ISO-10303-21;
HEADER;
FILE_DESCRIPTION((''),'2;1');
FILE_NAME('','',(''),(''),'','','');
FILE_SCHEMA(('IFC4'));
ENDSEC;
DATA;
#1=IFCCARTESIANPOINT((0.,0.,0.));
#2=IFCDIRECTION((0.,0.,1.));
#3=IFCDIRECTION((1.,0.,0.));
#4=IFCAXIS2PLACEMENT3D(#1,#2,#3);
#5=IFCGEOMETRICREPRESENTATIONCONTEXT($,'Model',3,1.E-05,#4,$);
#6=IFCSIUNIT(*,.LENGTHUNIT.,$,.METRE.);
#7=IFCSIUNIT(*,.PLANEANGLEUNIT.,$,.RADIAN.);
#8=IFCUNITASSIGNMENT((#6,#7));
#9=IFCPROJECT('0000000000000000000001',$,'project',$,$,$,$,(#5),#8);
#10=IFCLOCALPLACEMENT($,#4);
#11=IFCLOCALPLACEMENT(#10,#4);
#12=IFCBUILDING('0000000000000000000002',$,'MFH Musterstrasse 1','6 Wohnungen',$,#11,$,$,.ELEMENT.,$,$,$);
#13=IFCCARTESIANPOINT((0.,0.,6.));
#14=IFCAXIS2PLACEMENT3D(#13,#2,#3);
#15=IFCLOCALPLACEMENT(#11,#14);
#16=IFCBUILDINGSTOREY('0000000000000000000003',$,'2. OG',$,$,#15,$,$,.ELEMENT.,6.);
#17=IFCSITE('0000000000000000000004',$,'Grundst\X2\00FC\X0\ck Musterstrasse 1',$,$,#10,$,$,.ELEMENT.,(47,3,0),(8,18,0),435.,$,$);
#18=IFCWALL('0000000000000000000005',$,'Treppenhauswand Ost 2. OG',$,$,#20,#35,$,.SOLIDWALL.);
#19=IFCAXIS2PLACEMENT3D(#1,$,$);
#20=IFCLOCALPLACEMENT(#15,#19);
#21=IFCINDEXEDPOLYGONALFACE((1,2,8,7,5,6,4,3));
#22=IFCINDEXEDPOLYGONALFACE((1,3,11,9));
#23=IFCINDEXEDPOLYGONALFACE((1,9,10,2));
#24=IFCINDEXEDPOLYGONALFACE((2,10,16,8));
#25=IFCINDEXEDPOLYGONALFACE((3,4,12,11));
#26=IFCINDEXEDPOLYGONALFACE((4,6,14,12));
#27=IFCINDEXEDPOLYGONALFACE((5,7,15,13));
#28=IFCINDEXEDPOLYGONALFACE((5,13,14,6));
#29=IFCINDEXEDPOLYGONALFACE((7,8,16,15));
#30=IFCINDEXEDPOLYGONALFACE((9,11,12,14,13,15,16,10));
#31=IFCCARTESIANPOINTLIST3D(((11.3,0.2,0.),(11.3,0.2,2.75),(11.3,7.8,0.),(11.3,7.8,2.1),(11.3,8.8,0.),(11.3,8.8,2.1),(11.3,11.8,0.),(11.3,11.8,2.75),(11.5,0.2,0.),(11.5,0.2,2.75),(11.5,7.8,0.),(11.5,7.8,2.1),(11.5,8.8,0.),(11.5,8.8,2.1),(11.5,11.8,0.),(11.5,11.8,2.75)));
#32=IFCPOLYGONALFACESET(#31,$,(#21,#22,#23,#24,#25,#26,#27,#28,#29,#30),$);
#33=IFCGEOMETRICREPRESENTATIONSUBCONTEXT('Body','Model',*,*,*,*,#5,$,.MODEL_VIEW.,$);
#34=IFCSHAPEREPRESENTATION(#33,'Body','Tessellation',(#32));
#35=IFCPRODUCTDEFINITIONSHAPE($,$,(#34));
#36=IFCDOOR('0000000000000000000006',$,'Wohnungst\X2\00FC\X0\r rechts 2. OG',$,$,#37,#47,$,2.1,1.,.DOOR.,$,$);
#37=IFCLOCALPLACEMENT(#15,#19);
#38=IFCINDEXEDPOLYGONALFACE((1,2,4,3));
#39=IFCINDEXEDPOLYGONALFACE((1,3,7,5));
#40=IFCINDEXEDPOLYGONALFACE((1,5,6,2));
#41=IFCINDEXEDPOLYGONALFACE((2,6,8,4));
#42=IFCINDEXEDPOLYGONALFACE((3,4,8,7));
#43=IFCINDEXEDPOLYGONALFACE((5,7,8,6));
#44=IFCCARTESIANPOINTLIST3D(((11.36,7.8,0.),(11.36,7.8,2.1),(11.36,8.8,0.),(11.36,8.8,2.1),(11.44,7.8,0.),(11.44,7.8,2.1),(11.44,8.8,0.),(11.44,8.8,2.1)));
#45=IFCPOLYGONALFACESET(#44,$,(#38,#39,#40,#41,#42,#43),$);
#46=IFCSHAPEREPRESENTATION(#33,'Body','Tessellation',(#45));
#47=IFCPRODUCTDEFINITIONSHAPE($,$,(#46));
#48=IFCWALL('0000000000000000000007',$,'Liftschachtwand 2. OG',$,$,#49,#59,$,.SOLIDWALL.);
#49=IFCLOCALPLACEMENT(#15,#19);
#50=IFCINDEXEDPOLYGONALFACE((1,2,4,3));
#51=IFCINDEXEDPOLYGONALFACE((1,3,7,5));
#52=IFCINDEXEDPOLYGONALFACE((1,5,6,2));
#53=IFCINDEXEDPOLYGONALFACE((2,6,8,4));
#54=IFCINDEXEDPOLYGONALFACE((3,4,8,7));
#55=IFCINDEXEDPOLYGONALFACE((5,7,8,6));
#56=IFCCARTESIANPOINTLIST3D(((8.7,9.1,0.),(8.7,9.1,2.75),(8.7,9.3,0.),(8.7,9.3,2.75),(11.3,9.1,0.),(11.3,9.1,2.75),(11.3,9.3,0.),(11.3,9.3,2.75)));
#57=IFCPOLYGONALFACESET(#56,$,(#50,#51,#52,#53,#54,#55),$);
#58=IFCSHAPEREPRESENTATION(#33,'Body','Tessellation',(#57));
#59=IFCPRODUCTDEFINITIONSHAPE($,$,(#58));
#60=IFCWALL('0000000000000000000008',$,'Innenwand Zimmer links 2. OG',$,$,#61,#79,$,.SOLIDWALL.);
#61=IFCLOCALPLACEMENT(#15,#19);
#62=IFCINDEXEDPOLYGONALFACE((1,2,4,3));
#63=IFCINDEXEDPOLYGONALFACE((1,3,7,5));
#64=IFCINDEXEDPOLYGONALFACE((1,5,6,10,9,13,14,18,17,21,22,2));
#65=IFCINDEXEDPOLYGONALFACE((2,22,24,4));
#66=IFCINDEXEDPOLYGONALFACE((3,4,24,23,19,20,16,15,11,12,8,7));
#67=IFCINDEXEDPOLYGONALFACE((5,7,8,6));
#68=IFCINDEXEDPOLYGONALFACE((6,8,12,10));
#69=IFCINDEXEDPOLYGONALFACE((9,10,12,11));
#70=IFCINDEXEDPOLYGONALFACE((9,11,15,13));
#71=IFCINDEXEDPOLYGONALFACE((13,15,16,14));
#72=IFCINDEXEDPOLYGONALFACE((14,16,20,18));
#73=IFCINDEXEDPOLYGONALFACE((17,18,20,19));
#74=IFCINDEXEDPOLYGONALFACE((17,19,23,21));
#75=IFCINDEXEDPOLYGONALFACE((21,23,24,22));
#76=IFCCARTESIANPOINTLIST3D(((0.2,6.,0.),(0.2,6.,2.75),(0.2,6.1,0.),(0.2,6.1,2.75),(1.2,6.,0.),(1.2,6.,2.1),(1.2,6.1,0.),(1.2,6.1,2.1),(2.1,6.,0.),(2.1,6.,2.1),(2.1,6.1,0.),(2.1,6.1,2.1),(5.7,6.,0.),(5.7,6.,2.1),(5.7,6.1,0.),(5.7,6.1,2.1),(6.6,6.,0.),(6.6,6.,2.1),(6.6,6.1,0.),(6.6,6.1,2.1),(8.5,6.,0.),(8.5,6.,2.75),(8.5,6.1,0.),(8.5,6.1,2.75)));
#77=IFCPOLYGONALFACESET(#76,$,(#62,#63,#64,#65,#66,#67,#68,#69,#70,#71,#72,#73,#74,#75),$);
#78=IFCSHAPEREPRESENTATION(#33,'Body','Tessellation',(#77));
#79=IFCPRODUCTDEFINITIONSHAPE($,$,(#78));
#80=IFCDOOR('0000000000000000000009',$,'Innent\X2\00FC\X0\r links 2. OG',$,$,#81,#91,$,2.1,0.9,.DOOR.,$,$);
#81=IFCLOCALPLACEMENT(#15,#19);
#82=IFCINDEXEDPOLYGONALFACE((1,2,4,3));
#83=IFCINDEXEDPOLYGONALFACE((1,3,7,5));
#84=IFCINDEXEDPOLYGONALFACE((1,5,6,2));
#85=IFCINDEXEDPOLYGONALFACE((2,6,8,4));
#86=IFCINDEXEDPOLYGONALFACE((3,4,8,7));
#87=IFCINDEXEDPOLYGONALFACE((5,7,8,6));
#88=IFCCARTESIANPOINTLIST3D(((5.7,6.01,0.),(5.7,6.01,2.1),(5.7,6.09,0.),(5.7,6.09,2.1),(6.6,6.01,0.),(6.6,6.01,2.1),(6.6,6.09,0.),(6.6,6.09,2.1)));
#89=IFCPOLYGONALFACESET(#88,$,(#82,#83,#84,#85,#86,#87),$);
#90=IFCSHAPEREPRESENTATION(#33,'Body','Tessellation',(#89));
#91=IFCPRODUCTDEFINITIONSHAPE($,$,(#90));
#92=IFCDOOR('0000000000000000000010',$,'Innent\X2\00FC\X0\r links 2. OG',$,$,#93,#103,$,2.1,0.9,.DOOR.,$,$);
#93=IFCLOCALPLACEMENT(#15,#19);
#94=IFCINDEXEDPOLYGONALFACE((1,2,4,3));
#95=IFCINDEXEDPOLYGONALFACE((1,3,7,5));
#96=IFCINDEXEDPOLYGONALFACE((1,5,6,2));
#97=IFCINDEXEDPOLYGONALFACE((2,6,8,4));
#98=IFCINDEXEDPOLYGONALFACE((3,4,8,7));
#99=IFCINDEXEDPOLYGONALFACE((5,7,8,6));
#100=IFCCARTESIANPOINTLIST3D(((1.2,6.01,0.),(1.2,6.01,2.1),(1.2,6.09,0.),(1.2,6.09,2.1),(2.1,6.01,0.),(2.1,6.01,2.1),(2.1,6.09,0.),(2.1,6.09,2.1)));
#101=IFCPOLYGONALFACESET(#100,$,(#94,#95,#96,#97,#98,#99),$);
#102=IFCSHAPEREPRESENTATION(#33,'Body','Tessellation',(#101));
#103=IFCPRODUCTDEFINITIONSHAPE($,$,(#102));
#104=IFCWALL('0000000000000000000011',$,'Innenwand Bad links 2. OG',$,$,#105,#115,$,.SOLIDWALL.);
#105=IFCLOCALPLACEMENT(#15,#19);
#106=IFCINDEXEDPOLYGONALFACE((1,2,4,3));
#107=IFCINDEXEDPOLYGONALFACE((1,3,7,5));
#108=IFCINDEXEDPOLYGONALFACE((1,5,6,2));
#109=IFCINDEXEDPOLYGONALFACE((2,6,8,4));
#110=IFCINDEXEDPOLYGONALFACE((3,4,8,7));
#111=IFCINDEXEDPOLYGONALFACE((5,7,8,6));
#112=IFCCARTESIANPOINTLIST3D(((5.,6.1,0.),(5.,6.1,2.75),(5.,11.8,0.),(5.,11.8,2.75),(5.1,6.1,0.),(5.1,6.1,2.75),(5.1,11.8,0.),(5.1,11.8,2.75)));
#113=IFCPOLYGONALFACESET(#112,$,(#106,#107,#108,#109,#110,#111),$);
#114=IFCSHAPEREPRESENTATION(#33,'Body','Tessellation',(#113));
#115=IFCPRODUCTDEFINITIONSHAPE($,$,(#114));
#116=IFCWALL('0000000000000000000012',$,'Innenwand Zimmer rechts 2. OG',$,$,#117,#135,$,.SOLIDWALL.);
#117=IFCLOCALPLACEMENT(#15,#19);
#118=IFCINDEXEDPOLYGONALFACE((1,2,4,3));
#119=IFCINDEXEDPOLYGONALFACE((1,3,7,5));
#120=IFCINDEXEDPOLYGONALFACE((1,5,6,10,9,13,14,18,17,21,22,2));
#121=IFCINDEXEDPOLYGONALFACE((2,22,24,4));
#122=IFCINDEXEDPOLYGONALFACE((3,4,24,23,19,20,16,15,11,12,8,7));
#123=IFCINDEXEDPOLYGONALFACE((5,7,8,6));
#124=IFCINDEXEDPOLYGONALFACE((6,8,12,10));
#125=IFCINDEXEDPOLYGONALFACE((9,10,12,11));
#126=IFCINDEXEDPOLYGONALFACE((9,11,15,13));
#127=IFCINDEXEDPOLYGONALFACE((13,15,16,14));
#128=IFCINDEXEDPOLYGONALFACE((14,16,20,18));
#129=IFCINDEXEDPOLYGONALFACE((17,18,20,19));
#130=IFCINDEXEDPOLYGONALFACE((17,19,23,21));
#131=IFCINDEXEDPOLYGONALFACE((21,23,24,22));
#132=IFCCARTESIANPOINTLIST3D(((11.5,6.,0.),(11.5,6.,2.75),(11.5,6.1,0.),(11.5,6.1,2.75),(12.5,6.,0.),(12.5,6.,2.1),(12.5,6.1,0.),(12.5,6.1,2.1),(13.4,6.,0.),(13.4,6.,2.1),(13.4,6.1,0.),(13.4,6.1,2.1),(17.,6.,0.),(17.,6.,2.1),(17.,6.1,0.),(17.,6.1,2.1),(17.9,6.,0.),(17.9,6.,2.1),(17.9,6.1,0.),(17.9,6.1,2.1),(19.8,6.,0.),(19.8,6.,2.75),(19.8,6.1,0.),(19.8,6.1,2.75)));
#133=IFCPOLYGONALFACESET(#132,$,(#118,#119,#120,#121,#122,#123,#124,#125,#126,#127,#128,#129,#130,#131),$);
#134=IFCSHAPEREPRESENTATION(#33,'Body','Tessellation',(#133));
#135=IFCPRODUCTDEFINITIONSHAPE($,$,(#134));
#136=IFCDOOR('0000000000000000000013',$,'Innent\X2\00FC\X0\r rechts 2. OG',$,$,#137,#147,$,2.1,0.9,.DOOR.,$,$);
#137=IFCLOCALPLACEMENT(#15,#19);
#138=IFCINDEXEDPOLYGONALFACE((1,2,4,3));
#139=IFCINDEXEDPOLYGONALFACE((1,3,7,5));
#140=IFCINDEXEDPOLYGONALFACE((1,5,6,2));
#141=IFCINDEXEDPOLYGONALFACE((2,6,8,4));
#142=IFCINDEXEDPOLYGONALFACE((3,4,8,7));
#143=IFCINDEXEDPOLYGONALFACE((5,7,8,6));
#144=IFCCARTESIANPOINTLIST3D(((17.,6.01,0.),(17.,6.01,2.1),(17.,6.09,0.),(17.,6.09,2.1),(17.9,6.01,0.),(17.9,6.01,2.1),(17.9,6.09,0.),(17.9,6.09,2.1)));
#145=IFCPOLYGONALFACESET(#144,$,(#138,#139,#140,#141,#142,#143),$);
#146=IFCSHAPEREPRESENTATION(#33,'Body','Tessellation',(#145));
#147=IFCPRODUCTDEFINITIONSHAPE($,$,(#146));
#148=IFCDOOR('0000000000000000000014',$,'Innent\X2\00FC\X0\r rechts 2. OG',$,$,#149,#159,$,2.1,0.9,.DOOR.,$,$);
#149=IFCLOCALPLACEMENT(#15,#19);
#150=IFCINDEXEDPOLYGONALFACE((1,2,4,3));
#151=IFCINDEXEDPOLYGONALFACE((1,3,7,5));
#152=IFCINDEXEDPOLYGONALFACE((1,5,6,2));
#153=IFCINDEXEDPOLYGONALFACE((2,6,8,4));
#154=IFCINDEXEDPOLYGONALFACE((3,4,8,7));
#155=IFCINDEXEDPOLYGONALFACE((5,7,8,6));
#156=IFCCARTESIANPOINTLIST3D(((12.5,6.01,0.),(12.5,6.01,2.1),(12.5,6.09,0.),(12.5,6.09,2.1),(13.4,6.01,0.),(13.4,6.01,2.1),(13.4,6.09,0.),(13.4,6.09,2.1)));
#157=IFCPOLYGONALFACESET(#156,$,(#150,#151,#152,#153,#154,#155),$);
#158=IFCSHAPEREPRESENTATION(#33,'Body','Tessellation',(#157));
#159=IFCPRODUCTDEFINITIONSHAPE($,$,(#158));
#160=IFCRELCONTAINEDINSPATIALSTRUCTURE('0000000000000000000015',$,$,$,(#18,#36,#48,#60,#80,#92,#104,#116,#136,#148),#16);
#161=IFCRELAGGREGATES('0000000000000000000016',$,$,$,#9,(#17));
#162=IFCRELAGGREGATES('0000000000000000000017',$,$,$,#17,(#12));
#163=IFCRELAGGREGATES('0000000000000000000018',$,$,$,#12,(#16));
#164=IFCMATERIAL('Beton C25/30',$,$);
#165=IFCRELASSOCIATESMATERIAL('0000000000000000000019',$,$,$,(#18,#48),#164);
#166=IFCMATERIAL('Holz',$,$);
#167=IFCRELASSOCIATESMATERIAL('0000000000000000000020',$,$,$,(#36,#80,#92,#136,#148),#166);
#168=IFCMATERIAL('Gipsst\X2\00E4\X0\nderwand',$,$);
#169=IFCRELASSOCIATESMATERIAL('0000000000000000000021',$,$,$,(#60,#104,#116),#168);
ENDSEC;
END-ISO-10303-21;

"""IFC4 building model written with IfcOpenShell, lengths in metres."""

from ifc_helpers import new_model, si_unit, frame, frame_2d, origin_with_axes, place, context, subcontext, project, spatial, rectangle, extrude, material, element, fill, save


model = new_model("IFC4")

# Units and contexts
model_context = context("Model", 3, precision=1e-05, world=origin_with_axes())
body_context = subcontext(model_context, "Body", "Model", "MODEL_VIEW")
ifc_project = project(units=[si_unit("LENGTHUNIT", "METRE"), si_unit("PLANEANGLEUNIT", "RADIAN")], contexts=[model_context])

# Site, building, storey
site_placement = place(None, origin_with_axes())
site = spatial("IfcSite", under=ifc_project, at=site_placement, Name="Grundstück Musterstrasse 1", CompositionType="ELEMENT", RefLatitude=(47, 3, 0), RefLongitude=(8, 18, 0), RefElevation=435.0)
building_placement = place(site_placement, origin_with_axes())
building = spatial("IfcBuilding", under=site, at=building_placement, Name="MFH Musterstrasse 1", Description="6 Wohnungen", CompositionType="ELEMENT")
storey_placement = place(building_placement, frame((0.0, 0.0, 6.0), z_axis=(0.0, 0.0, 1.0), x_axis=(1.0, 0.0, 0.0)))
storey = spatial("IfcBuildingStorey", under=building, at=storey_placement, Name="2. OG", CompositionType="ELEMENT", Elevation=6.0)

# Wall, openings, door
ifc_material_1 = material(Name="Beton C25/30")
wall_1_placement = place(storey_placement, origin_with_axes())
wall_1 = element("IfcWall", 1, at=wall_1_placement, inside=storey, material=ifc_material_1, Name="Treppenhauswand Ost 2. OG", PredefinedType="SOLIDWALL", context=body_context, shape_type="SweptSolid", body=[
    extrude(rectangle(XDim=0.2, YDim=11.6, at=frame_2d((0.1, 5.8), x_axis=(1.0, 0.0))), frame((11.3, 0.2, 0.0), z_axis=(0.0, 0.0, 1.0), x_axis=(1.0, 0.0, 0.0)), (0.0, 0.0, 1.0), 2.75),
])
opening_1_placement = place(storey_placement, origin_with_axes())
element("IfcOpeningElement", 2, at=opening_1_placement, cuts=wall_1, PredefinedType="OPENING", context=body_context, shape_type="SweptSolid", body=[
    extrude(rectangle(XDim=0.3, YDim=1.0, at=frame_2d((0.15, 0.5), x_axis=(1.0, 0.0))), frame((11.25, 7.8, 0.0), z_axis=(0.0, 0.0, 1.0), x_axis=(1.0, 0.0, 0.0)), (0.0, 0.0, 1.0), 2.1),
])
opening_2_placement = place(storey_placement, origin_with_axes())
opening_2 = element("IfcOpeningElement", 3, at=opening_2_placement, cuts=wall_1, PredefinedType="OPENING", context=body_context, shape_type="SweptSolid", body=[
    extrude(rectangle(XDim=0.22, YDim=1.0, at=frame_2d((0.11, 0.5), x_axis=(1.0, 0.0))), frame((11.29, 7.8, 0.0), z_axis=(0.0, 0.0, 1.0), x_axis=(1.0, 0.0, 0.0)), (0.0, 0.0, 1.0), 2.1),
])
ifc_material_2 = material(Name="Holz")
door_1_placement = place(storey_placement, origin_with_axes())
door_1 = element("IfcDoor", 4, at=door_1_placement, inside=storey, material=ifc_material_2, Name="Wohnungstür rechts 2. OG", OverallHeight=2.1, OverallWidth=1.0, PredefinedType="DOOR", context=body_context, shape_type="SweptSolid", body=[
    extrude(rectangle(XDim=0.08, YDim=1.0, at=frame_2d((0.04, 0.5), x_axis=(1.0, 0.0))), frame((11.36, 7.8, 0.0), z_axis=(0.0, 0.0, 1.0), x_axis=(1.0, 0.0, 0.0)), (0.0, 0.0, 1.0), 2.1),
])
fill(opening_2, door_1)

# Wall
wall_2_placement = place(storey_placement, origin_with_axes())
element("IfcWall", 5, at=wall_2_placement, inside=storey, material=ifc_material_1, Name="Liftschachtwand 2. OG", PredefinedType="SOLIDWALL", context=body_context, shape_type="SweptSolid", body=[
    extrude(rectangle(XDim=2.6, YDim=0.2, at=frame_2d((1.3, 0.1), x_axis=(1.0, 0.0))), frame((8.7, 9.1, 0.0), z_axis=(0.0, 0.0, 1.0), x_axis=(1.0, 0.0, 0.0)), (0.0, 0.0, 1.0), 2.75),
])

# Wall, openings, doors
ifc_material_3 = material(Name="Gipsständerwand")
wall_3_placement = place(storey_placement, origin_with_axes())
wall_3 = element("IfcWall", 6, at=wall_3_placement, inside=storey, material=ifc_material_3, Name="Innenwand Zimmer links 2. OG", PredefinedType="SOLIDWALL", context=body_context, shape_type="SweptSolid", body=[
    extrude(rectangle(XDim=8.3, YDim=0.1, at=frame_2d((4.15, 0.05), x_axis=(1.0, 0.0))), frame((0.2, 6.0, 0.0), z_axis=(0.0, 0.0, 1.0), x_axis=(1.0, 0.0, 0.0)), (0.0, 0.0, 1.0), 2.75),
])
opening_3_placement = place(storey_placement, origin_with_axes())
element("IfcOpeningElement", 7, at=opening_3_placement, cuts=wall_3, PredefinedType="OPENING", context=body_context, shape_type="SweptSolid", body=[
    extrude(rectangle(XDim=0.9, YDim=0.2, at=frame_2d((0.45, 0.1), x_axis=(1.0, 0.0))), frame((5.7, 5.95, 0.0), z_axis=(0.0, 0.0, 1.0), x_axis=(1.0, 0.0, 0.0)), (0.0, 0.0, 1.0), 2.1),
])
opening_4_placement = place(storey_placement, origin_with_axes())
element("IfcOpeningElement", 8, at=opening_4_placement, cuts=wall_3, PredefinedType="OPENING", context=body_context, shape_type="SweptSolid", body=[
    extrude(rectangle(XDim=0.9, YDim=0.2, at=frame_2d((0.45, 0.1), x_axis=(1.0, 0.0))), frame((1.2, 5.95, 0.0), z_axis=(0.0, 0.0, 1.0), x_axis=(1.0, 0.0, 0.0)), (0.0, 0.0, 1.0), 2.1),
])
opening_5_placement = place(storey_placement, origin_with_axes())
opening_5 = element("IfcOpeningElement", 9, at=opening_5_placement, cuts=wall_3, PredefinedType="OPENING", context=body_context, shape_type="SweptSolid", body=[
    extrude(rectangle(XDim=0.9, YDim=0.12, at=frame_2d((0.45, 0.06), x_axis=(1.0, 0.0))), frame((5.7, 5.99, 0.0), z_axis=(0.0, 0.0, 1.0), x_axis=(1.0, 0.0, 0.0)), (0.0, 0.0, 1.0), 2.1),
])
opening_6_placement = place(storey_placement, origin_with_axes())
opening_6 = element("IfcOpeningElement", 10, at=opening_6_placement, cuts=wall_3, PredefinedType="OPENING", context=body_context, shape_type="SweptSolid", body=[
    extrude(rectangle(XDim=0.9, YDim=0.12, at=frame_2d((0.45, 0.06), x_axis=(1.0, 0.0))), frame((1.2, 5.99, 0.0), z_axis=(0.0, 0.0, 1.0), x_axis=(1.0, 0.0, 0.0)), (0.0, 0.0, 1.0), 2.1),
])
door_2_placement = place(storey_placement, origin_with_axes())
door_2 = element("IfcDoor", 11, at=door_2_placement, inside=storey, material=ifc_material_2, Name="Innentür links 2. OG", OverallHeight=2.1, OverallWidth=0.9, PredefinedType="DOOR", context=body_context, shape_type="SweptSolid", body=[
    extrude(rectangle(XDim=0.9, YDim=0.08, at=frame_2d((0.45, 0.04), x_axis=(1.0, 0.0))), frame((5.7, 6.01, 0.0), z_axis=(0.0, 0.0, 1.0), x_axis=(1.0, 0.0, 0.0)), (0.0, 0.0, 1.0), 2.1),
])
fill(opening_5, door_2)
door_3_placement = place(storey_placement, origin_with_axes())
door_3 = element("IfcDoor", 12, at=door_3_placement, inside=storey, material=ifc_material_2, Name="Innentür links 2. OG", OverallHeight=2.1, OverallWidth=0.9, PredefinedType="DOOR", context=body_context, shape_type="SweptSolid", body=[
    extrude(rectangle(XDim=0.9, YDim=0.08, at=frame_2d((0.45, 0.04), x_axis=(1.0, 0.0))), frame((1.2, 6.01, 0.0), z_axis=(0.0, 0.0, 1.0), x_axis=(1.0, 0.0, 0.0)), (0.0, 0.0, 1.0), 2.1),
])
fill(opening_6, door_3)

# Wall
wall_4_placement = place(storey_placement, origin_with_axes())
element("IfcWall", 13, at=wall_4_placement, inside=storey, material=ifc_material_3, Name="Innenwand Bad links 2. OG", PredefinedType="SOLIDWALL", context=body_context, shape_type="SweptSolid", body=[
    extrude(rectangle(XDim=0.1, YDim=5.7, at=frame_2d((0.05, 2.85), x_axis=(1.0, 0.0))), frame((5.0, 6.1, 0.0), z_axis=(0.0, 0.0, 1.0), x_axis=(1.0, 0.0, 0.0)), (0.0, 0.0, 1.0), 2.75),
])

# Wall, openings, doors
wall_5_placement = place(storey_placement, origin_with_axes())
wall_5 = element("IfcWall", 14, at=wall_5_placement, inside=storey, material=ifc_material_3, Name="Innenwand Zimmer rechts 2. OG", PredefinedType="SOLIDWALL", context=body_context, shape_type="SweptSolid", body=[
    extrude(rectangle(XDim=8.3, YDim=0.1, at=frame_2d((4.15, 0.05), x_axis=(1.0, 0.0))), frame((11.5, 6.0, 0.0), z_axis=(0.0, 0.0, 1.0), x_axis=(1.0, 0.0, 0.0)), (0.0, 0.0, 1.0), 2.75),
])
opening_7_placement = place(storey_placement, origin_with_axes())
element("IfcOpeningElement", 15, at=opening_7_placement, cuts=wall_5, PredefinedType="OPENING", context=body_context, shape_type="SweptSolid", body=[
    extrude(rectangle(XDim=0.9, YDim=0.2, at=frame_2d((0.45, 0.1), x_axis=(1.0, 0.0))), frame((17.0, 5.95, 0.0), z_axis=(0.0, 0.0, 1.0), x_axis=(1.0, 0.0, 0.0)), (0.0, 0.0, 1.0), 2.1),
])
opening_8_placement = place(storey_placement, origin_with_axes())
element("IfcOpeningElement", 16, at=opening_8_placement, cuts=wall_5, PredefinedType="OPENING", context=body_context, shape_type="SweptSolid", body=[
    extrude(rectangle(XDim=0.9, YDim=0.2, at=frame_2d((0.45, 0.1), x_axis=(1.0, 0.0))), frame((12.5, 5.95, 0.0), z_axis=(0.0, 0.0, 1.0), x_axis=(1.0, 0.0, 0.0)), (0.0, 0.0, 1.0), 2.1),
])
opening_9_placement = place(storey_placement, origin_with_axes())
opening_9 = element("IfcOpeningElement", 17, at=opening_9_placement, cuts=wall_5, PredefinedType="OPENING", context=body_context, shape_type="SweptSolid", body=[
    extrude(rectangle(XDim=0.9, YDim=0.12, at=frame_2d((0.45, 0.06), x_axis=(1.0, 0.0))), frame((17.0, 5.99, 0.0), z_axis=(0.0, 0.0, 1.0), x_axis=(1.0, 0.0, 0.0)), (0.0, 0.0, 1.0), 2.1),
])
opening_10_placement = place(storey_placement, origin_with_axes())
opening_10 = element("IfcOpeningElement", 18, at=opening_10_placement, cuts=wall_5, PredefinedType="OPENING", context=body_context, shape_type="SweptSolid", body=[
    extrude(rectangle(XDim=0.9, YDim=0.12, at=frame_2d((0.45, 0.06), x_axis=(1.0, 0.0))), frame((12.5, 5.99, 0.0), z_axis=(0.0, 0.0, 1.0), x_axis=(1.0, 0.0, 0.0)), (0.0, 0.0, 1.0), 2.1),
])
door_4_placement = place(storey_placement, origin_with_axes())
door_4 = element("IfcDoor", 19, at=door_4_placement, inside=storey, material=ifc_material_2, Name="Innentür rechts 2. OG", OverallHeight=2.1, OverallWidth=0.9, PredefinedType="DOOR", context=body_context, shape_type="SweptSolid", body=[
    extrude(rectangle(XDim=0.9, YDim=0.08, at=frame_2d((0.45, 0.04), x_axis=(1.0, 0.0))), frame((17.0, 6.01, 0.0), z_axis=(0.0, 0.0, 1.0), x_axis=(1.0, 0.0, 0.0)), (0.0, 0.0, 1.0), 2.1),
])
fill(opening_9, door_4)
door_5_placement = place(storey_placement, origin_with_axes())
door_5 = element("IfcDoor", 20, at=door_5_placement, inside=storey, material=ifc_material_2, Name="Innentür rechts 2. OG", OverallHeight=2.1, OverallWidth=0.9, PredefinedType="DOOR", context=body_context, shape_type="SweptSolid", body=[
    extrude(rectangle(XDim=0.9, YDim=0.08, at=frame_2d((0.45, 0.04), x_axis=(1.0, 0.0))), frame((12.5, 6.01, 0.0), z_axis=(0.0, 0.0, 1.0), x_axis=(1.0, 0.0, 0.0)), (0.0, 0.0, 1.0), 2.1),
])
fill(opening_10, door_5)

save(model, "model.ifc")
